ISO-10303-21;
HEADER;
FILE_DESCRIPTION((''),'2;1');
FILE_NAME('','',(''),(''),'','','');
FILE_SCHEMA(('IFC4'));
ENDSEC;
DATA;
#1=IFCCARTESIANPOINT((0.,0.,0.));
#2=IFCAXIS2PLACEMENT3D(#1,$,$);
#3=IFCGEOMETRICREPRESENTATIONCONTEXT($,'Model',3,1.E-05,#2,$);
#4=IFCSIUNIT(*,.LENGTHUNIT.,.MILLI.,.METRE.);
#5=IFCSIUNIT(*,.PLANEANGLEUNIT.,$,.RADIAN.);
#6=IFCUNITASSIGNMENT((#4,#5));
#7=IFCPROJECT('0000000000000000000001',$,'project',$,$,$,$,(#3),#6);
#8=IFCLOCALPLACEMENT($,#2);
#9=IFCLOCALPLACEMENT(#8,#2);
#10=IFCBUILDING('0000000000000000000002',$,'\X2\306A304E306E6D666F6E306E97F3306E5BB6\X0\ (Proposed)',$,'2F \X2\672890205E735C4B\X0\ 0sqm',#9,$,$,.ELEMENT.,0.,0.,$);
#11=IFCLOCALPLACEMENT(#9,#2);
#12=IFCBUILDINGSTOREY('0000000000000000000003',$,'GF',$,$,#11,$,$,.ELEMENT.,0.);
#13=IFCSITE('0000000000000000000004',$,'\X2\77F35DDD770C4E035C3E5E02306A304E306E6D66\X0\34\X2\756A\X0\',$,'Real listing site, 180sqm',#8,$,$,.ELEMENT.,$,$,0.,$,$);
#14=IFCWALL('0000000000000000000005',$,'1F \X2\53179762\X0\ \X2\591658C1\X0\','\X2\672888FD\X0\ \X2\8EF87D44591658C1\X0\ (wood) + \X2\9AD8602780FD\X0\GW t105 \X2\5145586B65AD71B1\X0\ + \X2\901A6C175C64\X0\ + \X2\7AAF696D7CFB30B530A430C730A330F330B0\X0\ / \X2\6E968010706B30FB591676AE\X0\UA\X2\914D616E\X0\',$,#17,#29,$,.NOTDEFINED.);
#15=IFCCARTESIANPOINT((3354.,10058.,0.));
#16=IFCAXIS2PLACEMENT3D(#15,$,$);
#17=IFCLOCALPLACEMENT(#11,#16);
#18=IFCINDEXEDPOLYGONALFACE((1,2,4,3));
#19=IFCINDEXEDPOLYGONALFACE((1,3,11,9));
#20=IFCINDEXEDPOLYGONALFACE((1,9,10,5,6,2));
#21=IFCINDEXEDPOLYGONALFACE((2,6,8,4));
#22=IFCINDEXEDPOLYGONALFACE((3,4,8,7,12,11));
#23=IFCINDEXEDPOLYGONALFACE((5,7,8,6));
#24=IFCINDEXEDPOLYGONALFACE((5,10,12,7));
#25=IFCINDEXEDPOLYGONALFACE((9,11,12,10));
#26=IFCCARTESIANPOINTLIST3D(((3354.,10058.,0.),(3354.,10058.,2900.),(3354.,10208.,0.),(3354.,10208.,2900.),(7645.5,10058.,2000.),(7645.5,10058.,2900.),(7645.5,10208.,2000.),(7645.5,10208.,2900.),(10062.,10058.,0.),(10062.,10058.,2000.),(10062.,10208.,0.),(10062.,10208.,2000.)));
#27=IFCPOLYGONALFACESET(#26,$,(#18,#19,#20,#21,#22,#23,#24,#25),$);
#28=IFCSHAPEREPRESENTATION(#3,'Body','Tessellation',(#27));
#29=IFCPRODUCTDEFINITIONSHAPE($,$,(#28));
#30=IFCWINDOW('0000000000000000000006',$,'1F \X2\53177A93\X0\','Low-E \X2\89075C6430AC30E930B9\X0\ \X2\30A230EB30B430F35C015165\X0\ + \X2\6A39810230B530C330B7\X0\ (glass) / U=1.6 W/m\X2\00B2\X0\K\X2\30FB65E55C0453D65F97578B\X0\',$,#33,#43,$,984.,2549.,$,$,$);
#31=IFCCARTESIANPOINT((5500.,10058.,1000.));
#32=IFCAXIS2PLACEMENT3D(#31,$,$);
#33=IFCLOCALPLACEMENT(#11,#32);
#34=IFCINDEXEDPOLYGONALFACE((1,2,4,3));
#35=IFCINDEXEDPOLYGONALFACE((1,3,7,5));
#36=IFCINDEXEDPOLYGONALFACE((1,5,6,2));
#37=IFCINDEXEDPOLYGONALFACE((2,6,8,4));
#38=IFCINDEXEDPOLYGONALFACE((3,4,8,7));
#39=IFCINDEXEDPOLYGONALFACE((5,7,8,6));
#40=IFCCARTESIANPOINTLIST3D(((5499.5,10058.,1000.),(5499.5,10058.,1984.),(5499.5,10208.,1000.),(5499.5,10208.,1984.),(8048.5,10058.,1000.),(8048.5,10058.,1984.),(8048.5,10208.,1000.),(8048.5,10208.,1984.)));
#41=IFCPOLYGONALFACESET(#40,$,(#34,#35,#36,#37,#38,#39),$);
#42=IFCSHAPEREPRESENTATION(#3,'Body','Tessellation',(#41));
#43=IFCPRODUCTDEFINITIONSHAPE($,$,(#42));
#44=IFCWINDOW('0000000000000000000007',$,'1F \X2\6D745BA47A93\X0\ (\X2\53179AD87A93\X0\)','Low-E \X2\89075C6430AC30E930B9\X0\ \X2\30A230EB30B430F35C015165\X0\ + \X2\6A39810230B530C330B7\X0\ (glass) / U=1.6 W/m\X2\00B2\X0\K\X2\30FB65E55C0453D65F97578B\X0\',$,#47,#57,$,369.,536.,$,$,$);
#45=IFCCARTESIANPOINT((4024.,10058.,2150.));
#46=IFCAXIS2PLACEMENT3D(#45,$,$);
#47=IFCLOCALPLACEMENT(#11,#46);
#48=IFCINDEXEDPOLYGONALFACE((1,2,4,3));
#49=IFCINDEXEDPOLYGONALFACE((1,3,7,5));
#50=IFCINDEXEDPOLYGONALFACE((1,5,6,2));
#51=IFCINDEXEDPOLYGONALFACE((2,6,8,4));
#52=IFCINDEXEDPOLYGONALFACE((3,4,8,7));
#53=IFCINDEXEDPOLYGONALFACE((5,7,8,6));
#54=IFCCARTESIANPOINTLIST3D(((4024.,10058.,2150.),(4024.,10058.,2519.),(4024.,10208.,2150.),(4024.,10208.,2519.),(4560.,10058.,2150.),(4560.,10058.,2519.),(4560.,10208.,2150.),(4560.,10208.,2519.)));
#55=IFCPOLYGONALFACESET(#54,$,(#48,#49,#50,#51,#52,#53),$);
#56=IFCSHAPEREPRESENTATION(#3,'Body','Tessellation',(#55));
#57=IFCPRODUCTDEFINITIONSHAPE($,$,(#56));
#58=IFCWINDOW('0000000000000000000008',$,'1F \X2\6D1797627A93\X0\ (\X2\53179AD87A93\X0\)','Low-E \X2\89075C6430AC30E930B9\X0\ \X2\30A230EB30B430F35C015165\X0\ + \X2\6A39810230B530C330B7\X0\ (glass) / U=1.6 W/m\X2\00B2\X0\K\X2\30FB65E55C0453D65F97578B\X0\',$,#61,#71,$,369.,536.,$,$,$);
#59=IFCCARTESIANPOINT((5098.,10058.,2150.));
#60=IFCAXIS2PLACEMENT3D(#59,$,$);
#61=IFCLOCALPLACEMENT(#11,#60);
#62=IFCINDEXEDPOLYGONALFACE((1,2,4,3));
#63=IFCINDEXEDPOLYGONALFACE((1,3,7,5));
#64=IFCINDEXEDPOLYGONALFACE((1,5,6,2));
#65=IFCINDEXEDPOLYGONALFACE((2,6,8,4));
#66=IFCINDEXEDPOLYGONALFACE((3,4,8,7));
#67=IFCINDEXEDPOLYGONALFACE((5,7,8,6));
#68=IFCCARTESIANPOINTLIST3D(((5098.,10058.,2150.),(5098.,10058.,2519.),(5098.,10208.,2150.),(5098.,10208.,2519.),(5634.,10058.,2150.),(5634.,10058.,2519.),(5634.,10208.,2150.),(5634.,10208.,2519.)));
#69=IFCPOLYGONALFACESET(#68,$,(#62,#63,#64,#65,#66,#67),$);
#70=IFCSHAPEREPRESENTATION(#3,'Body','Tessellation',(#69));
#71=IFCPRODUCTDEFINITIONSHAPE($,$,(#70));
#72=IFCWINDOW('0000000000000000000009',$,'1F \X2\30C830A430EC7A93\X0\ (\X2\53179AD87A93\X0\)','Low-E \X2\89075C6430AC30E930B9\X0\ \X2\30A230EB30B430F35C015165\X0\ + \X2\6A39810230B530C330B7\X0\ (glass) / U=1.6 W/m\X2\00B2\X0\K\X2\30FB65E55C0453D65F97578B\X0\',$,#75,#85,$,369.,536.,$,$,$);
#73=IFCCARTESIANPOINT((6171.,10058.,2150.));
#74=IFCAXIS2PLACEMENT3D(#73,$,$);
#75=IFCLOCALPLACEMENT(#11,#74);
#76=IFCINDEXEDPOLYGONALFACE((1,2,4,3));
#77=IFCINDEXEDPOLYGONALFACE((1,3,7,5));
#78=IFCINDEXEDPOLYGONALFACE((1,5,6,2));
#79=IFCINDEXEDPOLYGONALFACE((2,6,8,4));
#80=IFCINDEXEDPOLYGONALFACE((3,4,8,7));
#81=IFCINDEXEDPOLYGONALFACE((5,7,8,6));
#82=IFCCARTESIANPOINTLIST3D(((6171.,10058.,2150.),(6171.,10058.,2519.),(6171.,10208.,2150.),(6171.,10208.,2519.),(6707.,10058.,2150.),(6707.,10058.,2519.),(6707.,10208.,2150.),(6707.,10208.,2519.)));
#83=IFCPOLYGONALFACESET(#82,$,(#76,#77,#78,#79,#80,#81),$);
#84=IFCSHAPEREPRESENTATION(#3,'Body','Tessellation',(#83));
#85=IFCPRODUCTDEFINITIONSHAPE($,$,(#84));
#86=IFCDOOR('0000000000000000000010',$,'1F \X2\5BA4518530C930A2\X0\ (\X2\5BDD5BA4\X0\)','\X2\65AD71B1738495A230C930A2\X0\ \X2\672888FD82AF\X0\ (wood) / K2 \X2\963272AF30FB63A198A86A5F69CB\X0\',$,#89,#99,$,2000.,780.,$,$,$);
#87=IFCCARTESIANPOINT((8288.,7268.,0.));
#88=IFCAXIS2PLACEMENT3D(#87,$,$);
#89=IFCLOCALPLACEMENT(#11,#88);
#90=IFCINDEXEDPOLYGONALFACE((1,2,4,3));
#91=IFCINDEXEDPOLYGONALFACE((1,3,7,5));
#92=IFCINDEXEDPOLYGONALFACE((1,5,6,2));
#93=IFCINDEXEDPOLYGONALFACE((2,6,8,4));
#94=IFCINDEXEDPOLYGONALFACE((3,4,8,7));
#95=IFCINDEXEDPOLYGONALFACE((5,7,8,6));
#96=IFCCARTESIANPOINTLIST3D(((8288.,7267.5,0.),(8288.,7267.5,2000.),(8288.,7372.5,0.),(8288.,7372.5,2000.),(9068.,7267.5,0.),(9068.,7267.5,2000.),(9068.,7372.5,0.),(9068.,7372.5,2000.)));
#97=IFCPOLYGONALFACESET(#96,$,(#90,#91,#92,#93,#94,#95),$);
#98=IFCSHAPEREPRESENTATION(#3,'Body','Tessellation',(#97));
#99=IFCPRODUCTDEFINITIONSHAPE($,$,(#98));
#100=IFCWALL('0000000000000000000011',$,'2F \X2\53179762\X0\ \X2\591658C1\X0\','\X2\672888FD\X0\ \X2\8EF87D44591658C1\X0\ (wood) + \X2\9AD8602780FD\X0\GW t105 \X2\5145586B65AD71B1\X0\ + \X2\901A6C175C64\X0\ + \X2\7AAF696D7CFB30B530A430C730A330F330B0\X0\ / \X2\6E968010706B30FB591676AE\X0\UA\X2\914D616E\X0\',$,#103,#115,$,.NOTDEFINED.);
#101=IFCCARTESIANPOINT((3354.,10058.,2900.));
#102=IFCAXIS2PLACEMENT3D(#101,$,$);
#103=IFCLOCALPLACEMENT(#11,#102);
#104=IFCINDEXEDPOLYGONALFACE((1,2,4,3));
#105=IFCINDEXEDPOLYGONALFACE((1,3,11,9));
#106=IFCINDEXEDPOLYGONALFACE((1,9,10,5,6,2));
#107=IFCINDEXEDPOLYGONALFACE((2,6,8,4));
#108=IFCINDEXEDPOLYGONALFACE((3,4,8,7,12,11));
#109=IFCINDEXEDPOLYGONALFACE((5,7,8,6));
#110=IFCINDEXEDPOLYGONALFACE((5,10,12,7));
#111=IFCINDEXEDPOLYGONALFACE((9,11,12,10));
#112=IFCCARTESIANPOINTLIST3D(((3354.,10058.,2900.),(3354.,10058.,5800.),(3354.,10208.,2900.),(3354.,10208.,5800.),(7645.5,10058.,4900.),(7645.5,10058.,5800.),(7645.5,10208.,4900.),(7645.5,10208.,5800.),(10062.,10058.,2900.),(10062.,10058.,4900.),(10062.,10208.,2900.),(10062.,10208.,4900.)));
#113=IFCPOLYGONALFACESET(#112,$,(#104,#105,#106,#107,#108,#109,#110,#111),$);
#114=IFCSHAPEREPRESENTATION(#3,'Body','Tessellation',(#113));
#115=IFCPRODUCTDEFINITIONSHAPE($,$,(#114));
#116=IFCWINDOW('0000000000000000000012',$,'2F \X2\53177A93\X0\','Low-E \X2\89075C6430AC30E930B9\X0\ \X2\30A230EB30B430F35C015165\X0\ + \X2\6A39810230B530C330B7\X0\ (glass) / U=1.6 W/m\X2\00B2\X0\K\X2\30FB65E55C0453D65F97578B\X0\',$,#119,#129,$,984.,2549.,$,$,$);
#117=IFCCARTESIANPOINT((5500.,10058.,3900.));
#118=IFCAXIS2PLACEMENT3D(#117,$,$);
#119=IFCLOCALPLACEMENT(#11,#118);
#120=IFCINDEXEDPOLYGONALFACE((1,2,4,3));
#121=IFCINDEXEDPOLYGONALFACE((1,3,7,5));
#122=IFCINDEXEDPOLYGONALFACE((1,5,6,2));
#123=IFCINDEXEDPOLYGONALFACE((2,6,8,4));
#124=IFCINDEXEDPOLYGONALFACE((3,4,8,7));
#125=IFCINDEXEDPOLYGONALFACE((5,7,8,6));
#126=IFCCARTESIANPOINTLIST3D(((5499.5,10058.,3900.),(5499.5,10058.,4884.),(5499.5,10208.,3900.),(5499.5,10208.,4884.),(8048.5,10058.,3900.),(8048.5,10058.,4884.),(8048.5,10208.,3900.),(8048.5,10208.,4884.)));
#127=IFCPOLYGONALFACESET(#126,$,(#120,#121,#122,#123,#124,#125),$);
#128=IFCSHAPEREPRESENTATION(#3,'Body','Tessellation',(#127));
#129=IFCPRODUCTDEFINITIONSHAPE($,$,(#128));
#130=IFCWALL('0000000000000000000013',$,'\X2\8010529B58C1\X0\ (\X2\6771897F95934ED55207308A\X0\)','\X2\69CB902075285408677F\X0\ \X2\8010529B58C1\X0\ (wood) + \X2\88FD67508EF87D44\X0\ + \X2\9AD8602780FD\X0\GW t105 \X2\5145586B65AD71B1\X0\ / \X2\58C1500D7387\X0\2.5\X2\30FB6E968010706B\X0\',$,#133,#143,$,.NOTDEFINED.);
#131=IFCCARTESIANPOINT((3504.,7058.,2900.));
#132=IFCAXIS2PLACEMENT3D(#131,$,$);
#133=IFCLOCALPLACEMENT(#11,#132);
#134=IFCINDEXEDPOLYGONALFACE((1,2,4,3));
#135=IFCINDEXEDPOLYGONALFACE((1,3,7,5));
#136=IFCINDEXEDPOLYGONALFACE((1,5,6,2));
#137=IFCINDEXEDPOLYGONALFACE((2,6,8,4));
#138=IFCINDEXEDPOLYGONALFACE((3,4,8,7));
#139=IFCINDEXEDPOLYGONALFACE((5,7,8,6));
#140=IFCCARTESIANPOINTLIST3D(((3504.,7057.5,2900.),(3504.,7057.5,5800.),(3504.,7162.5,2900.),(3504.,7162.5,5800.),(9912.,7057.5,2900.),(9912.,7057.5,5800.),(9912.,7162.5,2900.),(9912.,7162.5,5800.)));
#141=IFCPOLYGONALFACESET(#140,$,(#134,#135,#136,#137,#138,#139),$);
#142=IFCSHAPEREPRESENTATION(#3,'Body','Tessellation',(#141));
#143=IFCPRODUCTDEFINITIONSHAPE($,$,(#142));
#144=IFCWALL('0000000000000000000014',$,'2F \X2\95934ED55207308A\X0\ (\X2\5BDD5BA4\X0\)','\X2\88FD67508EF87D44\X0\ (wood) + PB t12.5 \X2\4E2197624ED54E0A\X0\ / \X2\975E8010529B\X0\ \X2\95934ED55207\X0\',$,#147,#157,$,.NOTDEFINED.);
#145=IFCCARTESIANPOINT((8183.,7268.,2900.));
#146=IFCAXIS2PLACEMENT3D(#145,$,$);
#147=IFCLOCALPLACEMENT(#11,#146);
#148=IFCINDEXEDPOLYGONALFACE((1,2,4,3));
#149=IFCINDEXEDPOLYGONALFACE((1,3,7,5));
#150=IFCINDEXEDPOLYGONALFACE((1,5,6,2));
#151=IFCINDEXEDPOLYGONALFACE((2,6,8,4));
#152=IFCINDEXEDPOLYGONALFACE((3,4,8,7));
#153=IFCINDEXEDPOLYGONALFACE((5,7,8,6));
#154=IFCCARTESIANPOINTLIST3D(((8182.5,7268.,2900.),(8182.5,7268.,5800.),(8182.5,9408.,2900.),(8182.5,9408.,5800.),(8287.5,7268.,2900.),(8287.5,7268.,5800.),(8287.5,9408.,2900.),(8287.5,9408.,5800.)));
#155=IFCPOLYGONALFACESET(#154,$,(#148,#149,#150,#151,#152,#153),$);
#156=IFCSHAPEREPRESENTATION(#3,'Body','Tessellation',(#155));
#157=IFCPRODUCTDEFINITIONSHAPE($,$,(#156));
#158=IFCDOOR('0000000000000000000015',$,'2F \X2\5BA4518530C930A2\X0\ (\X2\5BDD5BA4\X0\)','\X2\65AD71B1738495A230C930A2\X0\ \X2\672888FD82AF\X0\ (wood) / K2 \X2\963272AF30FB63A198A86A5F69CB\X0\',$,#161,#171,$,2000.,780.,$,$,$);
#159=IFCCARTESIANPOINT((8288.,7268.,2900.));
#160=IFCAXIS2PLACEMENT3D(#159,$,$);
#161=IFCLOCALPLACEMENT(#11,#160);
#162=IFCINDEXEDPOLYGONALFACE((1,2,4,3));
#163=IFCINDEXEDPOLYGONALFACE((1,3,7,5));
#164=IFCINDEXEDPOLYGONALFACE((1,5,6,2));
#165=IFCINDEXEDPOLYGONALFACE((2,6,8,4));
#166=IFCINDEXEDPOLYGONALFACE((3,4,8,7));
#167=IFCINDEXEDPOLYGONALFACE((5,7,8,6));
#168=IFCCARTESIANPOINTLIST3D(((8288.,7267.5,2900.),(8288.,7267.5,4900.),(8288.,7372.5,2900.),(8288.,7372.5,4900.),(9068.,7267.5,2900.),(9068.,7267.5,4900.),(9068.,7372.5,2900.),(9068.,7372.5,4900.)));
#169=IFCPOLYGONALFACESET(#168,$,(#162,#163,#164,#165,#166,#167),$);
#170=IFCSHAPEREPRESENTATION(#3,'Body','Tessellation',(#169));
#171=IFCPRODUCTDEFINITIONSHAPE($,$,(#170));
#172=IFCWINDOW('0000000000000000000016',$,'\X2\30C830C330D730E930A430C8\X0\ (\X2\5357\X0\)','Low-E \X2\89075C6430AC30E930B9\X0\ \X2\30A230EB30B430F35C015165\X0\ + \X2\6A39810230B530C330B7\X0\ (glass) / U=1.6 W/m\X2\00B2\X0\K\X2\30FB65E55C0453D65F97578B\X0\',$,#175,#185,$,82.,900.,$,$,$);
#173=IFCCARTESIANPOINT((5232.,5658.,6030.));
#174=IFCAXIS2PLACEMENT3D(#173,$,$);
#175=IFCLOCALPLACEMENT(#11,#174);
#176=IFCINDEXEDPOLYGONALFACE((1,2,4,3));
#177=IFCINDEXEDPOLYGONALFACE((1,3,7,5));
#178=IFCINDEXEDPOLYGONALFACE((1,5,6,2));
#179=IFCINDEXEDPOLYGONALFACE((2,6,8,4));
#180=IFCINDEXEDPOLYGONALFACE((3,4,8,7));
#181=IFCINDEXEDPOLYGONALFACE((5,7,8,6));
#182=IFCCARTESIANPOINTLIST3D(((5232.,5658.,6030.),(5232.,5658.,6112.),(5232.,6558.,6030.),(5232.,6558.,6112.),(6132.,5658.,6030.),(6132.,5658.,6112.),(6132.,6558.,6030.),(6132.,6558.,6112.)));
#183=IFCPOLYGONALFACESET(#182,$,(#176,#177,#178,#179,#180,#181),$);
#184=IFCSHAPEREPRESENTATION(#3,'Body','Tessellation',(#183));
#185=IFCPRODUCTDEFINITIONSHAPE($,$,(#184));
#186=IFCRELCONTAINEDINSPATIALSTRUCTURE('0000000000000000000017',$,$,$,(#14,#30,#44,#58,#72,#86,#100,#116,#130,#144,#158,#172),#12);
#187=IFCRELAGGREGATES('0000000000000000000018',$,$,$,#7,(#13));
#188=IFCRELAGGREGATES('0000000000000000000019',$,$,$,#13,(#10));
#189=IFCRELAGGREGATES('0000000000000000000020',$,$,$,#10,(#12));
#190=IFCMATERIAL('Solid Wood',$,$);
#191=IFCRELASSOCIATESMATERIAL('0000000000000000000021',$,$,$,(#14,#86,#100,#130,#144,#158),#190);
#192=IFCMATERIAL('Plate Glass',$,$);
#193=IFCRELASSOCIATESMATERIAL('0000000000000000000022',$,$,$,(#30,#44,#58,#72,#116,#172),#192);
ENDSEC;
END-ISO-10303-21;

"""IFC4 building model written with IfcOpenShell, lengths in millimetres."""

from ifc_helpers import new_model, si_unit, frame, frame_2d, origin, place, context, project, spatial, rectangle, extrude, material, element, fill, save


model = new_model("IFC4")

# Units and contexts
model_context = context("Model", 3, precision=1e-05, world=origin())
ifc_project = project(units=[si_unit("LENGTHUNIT", "METRE", prefix="MILLI"), si_unit("PLANEANGLEUNIT", "RADIAN")], contexts=[model_context])

# Site, building, storey
site_placement = place(None, origin())
site = spatial("IfcSite", under=ifc_project, at=site_placement, Name="石川県七尾市なぎの浦34番", ObjectType="Real listing site, 180sqm", CompositionType="ELEMENT", RefElevation=0.0)
building_placement = place(site_placement, origin())
building = spatial("IfcBuilding", under=site, at=building_placement, Name="なぎの浦潮の音の家 (Proposed)", ObjectType="2F 木造平屋 0sqm", CompositionType="ELEMENT", ElevationOfRefHeight=0.0, ElevationOfTerrain=0.0)
storey_placement = place(building_placement, origin())
storey = spatial("IfcBuildingStorey", under=building, at=storey_placement, Name="GF", CompositionType="ELEMENT", Elevation=0.0)

# Wall, openings, windows
ifc_material_1 = material(Name="Solid Wood")
wall_1_placement = place(storey_placement, frame((3354.0, 10058.0, 0.0)))
wall_1 = element("IfcWall", 1, at=wall_1_placement, inside=storey, material=ifc_material_1, Name="1F 北面 外壁", Description="木製 軸組外壁 (wood) + 高性能GW t105 充填断熱 + 通気層 + 窯業系サイディング / 準耐火・外皮UA配慮", PredefinedType="NOTDEFINED", context=model_context, shape_type="SweptSolid", body=[
    extrude(rectangle(XDim=6708.0, YDim=150.0, at=frame_2d((3354.0, 75.0))), frame((3354.0, 10058.0, 0.0)), (0.0, 0.0, 1.0), 2900.0),
])
opening_1_placement = place(storey_placement, frame((5500.0, 10058.0, 1000.0)))
opening_1 = element("IfcOpeningElement", 2, at=opening_1_placement, cuts=wall_1, PredefinedType="NOTDEFINED", context=model_context, shape_type="SweptSolid", body=[
    extrude(rectangle(XDim=2549.0, YDim=150.0, at=frame_2d((1274.0, 75.0))), frame((5500.0, 10058.0, 1000.0)), (0.0, 0.0, 1.0), 984.0),
])
opening_2_placement = place(storey_placement, frame((4024.0, 10058.0, 2150.0)))
opening_2 = element("IfcOpeningElement", 3, at=opening_2_placement, cuts=wall_1, PredefinedType="NOTDEFINED", context=model_context, shape_type="SweptSolid", body=[
    extrude(rectangle(XDim=536.0, YDim=150.0, at=frame_2d((268.0, 75.0))), frame((4024.0, 10058.0, 2150.0)), (0.0, 0.0, 1.0), 369.0),
])
opening_3_placement = place(storey_placement, frame((5098.0, 10058.0, 2150.0)))
opening_3 = element("IfcOpeningElement", 4, at=opening_3_placement, cuts=wall_1, PredefinedType="NOTDEFINED", context=model_context, shape_type="SweptSolid", body=[
    extrude(rectangle(XDim=536.0, YDim=150.0, at=frame_2d((268.0, 75.0))), frame((5098.0, 10058.0, 2150.0)), (0.0, 0.0, 1.0), 369.0),
])
opening_4_placement = place(storey_placement, frame((6171.0, 10058.0, 2150.0)))
opening_4 = element("IfcOpeningElement", 5, at=opening_4_placement, cuts=wall_1, PredefinedType="NOTDEFINED", context=model_context, shape_type="SweptSolid", body=[
    extrude(rectangle(XDim=536.0, YDim=150.0, at=frame_2d((268.0, 75.0))), frame((6171.0, 10058.0, 2150.0)), (0.0, 0.0, 1.0), 369.0),
])
ifc_material_2 = material(Name="Plate Glass")
window_1_placement = place(storey_placement, frame((5500.0, 10058.0, 1000.0)))
window_1 = element("IfcWindow", 6, at=window_1_placement, inside=storey, material=ifc_material_2, Name="1F 北窓", Description="Low-E 複層ガラス アルゴン封入 + 樹脂サッシ (glass) / U=1.6 W/m²K・日射取得型", OverallHeight=984.0, OverallWidth=2549.0, context=model_context, shape_type="SweptSolid", body=[
    extrude(rectangle(XDim=2549.0, YDim=150.0, at=frame_2d((1274.0, 75.0))), frame((5500.0, 10058.0, 1000.0)), (0.0, 0.0, 1.0), 984.0),
])
fill(opening_1, window_1)
window_2_placement = place(storey_placement, frame((4024.0, 10058.0, 2150.0)))
window_2 = element("IfcWindow", 7, at=window_2_placement, inside=storey, material=ifc_material_2, Name="1F 浴室窓 (北高窓)", Description="Low-E 複層ガラス アルゴン封入 + 樹脂サッシ (glass) / U=1.6 W/m²K・日射取得型", OverallHeight=369.0, OverallWidth=536.0, context=model_context, shape_type="SweptSolid", body=[
    extrude(rectangle(XDim=536.0, YDim=150.0, at=frame_2d((268.0, 75.0))), frame((4024.0, 10058.0, 2150.0)), (0.0, 0.0, 1.0), 369.0),
])
fill(opening_2, window_2)
window_3_placement = place(storey_placement, frame((5098.0, 10058.0, 2150.0)))
window_3 = element("IfcWindow", 8, at=window_3_placement, inside=storey, material=ifc_material_2, Name="1F 洗面窓 (北高窓)", Description="Low-E 複層ガラス アルゴン封入 + 樹脂サッシ (glass) / U=1.6 W/m²K・日射取得型", OverallHeight=369.0, OverallWidth=536.0, context=model_context, shape_type="SweptSolid", body=[
    extrude(rectangle(XDim=536.0, YDim=150.0, at=frame_2d((268.0, 75.0))), frame((5098.0, 10058.0, 2150.0)), (0.0, 0.0, 1.0), 369.0),
])
fill(opening_3, window_3)
window_4_placement = place(storey_placement, frame((6171.0, 10058.0, 2150.0)))
window_4 = element("IfcWindow", 9, at=window_4_placement, inside=storey, material=ifc_material_2, Name="1F トイレ窓 (北高窓)", Description="Low-E 複層ガラス アルゴン封入 + 樹脂サッシ (glass) / U=1.6 W/m²K・日射取得型", OverallHeight=369.0, OverallWidth=536.0, context=model_context, shape_type="SweptSolid", body=[
    extrude(rectangle(XDim=536.0, YDim=150.0, at=frame_2d((268.0, 75.0))), frame((6171.0, 10058.0, 2150.0)), (0.0, 0.0, 1.0), 369.0),
])
fill(opening_4, window_4)

# Door
door_1_placement = place(storey_placement, frame((8288.0, 7268.0, 0.0)))
element("IfcDoor", 10, at=door_1_placement, inside=storey, material=ifc_material_1, Name="1F 室内ドア (寝室)", Description="断熱玄関ドア 木製芯 (wood) / K2 防犯・採風機構", OverallHeight=2000.0, OverallWidth=780.0, context=model_context, shape_type="SweptSolid", body=[
    extrude(rectangle(XDim=780.0, YDim=105.0, at=frame_2d((390.0, 52.0))), frame((8288.0, 7268.0, 0.0)), (0.0, 0.0, 1.0), 2000.0),
])

# Wall, opening, window
wall_2_placement = place(storey_placement, frame((3354.0, 10058.0, 2900.0)))
wall_2 = element("IfcWall", 11, at=wall_2_placement, inside=storey, material=ifc_material_1, Name="2F 北面 外壁", Description="木製 軸組外壁 (wood) + 高性能GW t105 充填断熱 + 通気層 + 窯業系サイディング / 準耐火・外皮UA配慮", PredefinedType="NOTDEFINED", context=model_context, shape_type="SweptSolid", body=[
    extrude(rectangle(XDim=6708.0, YDim=150.0, at=frame_2d((3354.0, 75.0))), frame((3354.0, 10058.0, 2900.0)), (0.0, 0.0, 1.0), 2900.0),
])
opening_5_placement = place(storey_placement, frame((5500.0, 10058.0, 3900.0)))
opening_5 = element("IfcOpeningElement", 12, at=opening_5_placement, cuts=wall_2, PredefinedType="NOTDEFINED", context=model_context, shape_type="SweptSolid", body=[
    extrude(rectangle(XDim=2549.0, YDim=150.0, at=frame_2d((1274.0, 75.0))), frame((5500.0, 10058.0, 3900.0)), (0.0, 0.0, 1.0), 984.0),
])
window_5_placement = place(storey_placement, frame((5500.0, 10058.0, 3900.0)))
window_5 = element("IfcWindow", 13, at=window_5_placement, inside=storey, material=ifc_material_2, Name="2F 北窓", Description="Low-E 複層ガラス アルゴン封入 + 樹脂サッシ (glass) / U=1.6 W/m²K・日射取得型", OverallHeight=984.0, OverallWidth=2549.0, context=model_context, shape_type="SweptSolid", body=[
    extrude(rectangle(XDim=2549.0, YDim=150.0, at=frame_2d((1274.0, 75.0))), frame((5500.0, 10058.0, 3900.0)), (0.0, 0.0, 1.0), 984.0),
])
fill(opening_5, window_5)

# Walls
wall_3_placement = place(storey_placement, frame((3504.0, 7058.0, 2900.0)))
element("IfcWall", 14, at=wall_3_placement, inside=storey, material=ifc_material_1, Name="耐力壁 (東西間仕切り)", Description="構造用合板 耐力壁 (wood) + 製材軸組 + 高性能GW t105 充填断熱 / 壁倍率2.5・準耐火", PredefinedType="NOTDEFINED", context=model_context, shape_type="SweptSolid", body=[
    extrude(rectangle(XDim=6408.0, YDim=105.0, at=frame_2d((3204.0, 52.0))), frame((3504.0, 7058.0, 2900.0)), (0.0, 0.0, 1.0), 2900.0),
])
wall_4_placement = place(storey_placement, frame((8183.0, 7268.0, 2900.0)))
element("IfcWall", 15, at=wall_4_placement, inside=storey, material=ifc_material_1, Name="2F 間仕切り (寝室)", Description="製材軸組 (wood) + PB t12.5 両面仕上 / 非耐力 間仕切", PredefinedType="NOTDEFINED", context=model_context, shape_type="SweptSolid", body=[
    extrude(rectangle(XDim=105.0, YDim=2140.0, at=frame_2d((52.0, 1070.0))), frame((8183.0, 7268.0, 2900.0)), (0.0, 0.0, 1.0), 2900.0),
])

# Door
door_2_placement = place(storey_placement, frame((8288.0, 7268.0, 2900.0)))
element("IfcDoor", 16, at=door_2_placement, inside=storey, material=ifc_material_1, Name="2F 室内ドア (寝室)", Description="断熱玄関ドア 木製芯 (wood) / K2 防犯・採風機構", OverallHeight=2000.0, OverallWidth=780.0, context=model_context, shape_type="SweptSolid", body=[
    extrude(rectangle(XDim=780.0, YDim=105.0, at=frame_2d((390.0, 52.0))), frame((8288.0, 7268.0, 2900.0)), (0.0, 0.0, 1.0), 2000.0),
])

# Window
window_6_placement = place(storey_placement, frame((5232.0, 5658.0, 6030.0)))
element("IfcWindow", 17, at=window_6_placement, inside=storey, material=ifc_material_2, Name="トップライト (南)", Description="Low-E 複層ガラス アルゴン封入 + 樹脂サッシ (glass) / U=1.6 W/m²K・日射取得型", OverallHeight=82.0, OverallWidth=900.0, context=model_context, shape_type="SweptSolid", body=[
    extrude(rectangle(XDim=900.0, YDim=900.0, at=frame_2d((450.0, 450.0))), frame((5232.0, 5658.0, 6030.0)), (0.0, 0.0, 1.0), 82.0),
])

save(model, "model.ifc")
